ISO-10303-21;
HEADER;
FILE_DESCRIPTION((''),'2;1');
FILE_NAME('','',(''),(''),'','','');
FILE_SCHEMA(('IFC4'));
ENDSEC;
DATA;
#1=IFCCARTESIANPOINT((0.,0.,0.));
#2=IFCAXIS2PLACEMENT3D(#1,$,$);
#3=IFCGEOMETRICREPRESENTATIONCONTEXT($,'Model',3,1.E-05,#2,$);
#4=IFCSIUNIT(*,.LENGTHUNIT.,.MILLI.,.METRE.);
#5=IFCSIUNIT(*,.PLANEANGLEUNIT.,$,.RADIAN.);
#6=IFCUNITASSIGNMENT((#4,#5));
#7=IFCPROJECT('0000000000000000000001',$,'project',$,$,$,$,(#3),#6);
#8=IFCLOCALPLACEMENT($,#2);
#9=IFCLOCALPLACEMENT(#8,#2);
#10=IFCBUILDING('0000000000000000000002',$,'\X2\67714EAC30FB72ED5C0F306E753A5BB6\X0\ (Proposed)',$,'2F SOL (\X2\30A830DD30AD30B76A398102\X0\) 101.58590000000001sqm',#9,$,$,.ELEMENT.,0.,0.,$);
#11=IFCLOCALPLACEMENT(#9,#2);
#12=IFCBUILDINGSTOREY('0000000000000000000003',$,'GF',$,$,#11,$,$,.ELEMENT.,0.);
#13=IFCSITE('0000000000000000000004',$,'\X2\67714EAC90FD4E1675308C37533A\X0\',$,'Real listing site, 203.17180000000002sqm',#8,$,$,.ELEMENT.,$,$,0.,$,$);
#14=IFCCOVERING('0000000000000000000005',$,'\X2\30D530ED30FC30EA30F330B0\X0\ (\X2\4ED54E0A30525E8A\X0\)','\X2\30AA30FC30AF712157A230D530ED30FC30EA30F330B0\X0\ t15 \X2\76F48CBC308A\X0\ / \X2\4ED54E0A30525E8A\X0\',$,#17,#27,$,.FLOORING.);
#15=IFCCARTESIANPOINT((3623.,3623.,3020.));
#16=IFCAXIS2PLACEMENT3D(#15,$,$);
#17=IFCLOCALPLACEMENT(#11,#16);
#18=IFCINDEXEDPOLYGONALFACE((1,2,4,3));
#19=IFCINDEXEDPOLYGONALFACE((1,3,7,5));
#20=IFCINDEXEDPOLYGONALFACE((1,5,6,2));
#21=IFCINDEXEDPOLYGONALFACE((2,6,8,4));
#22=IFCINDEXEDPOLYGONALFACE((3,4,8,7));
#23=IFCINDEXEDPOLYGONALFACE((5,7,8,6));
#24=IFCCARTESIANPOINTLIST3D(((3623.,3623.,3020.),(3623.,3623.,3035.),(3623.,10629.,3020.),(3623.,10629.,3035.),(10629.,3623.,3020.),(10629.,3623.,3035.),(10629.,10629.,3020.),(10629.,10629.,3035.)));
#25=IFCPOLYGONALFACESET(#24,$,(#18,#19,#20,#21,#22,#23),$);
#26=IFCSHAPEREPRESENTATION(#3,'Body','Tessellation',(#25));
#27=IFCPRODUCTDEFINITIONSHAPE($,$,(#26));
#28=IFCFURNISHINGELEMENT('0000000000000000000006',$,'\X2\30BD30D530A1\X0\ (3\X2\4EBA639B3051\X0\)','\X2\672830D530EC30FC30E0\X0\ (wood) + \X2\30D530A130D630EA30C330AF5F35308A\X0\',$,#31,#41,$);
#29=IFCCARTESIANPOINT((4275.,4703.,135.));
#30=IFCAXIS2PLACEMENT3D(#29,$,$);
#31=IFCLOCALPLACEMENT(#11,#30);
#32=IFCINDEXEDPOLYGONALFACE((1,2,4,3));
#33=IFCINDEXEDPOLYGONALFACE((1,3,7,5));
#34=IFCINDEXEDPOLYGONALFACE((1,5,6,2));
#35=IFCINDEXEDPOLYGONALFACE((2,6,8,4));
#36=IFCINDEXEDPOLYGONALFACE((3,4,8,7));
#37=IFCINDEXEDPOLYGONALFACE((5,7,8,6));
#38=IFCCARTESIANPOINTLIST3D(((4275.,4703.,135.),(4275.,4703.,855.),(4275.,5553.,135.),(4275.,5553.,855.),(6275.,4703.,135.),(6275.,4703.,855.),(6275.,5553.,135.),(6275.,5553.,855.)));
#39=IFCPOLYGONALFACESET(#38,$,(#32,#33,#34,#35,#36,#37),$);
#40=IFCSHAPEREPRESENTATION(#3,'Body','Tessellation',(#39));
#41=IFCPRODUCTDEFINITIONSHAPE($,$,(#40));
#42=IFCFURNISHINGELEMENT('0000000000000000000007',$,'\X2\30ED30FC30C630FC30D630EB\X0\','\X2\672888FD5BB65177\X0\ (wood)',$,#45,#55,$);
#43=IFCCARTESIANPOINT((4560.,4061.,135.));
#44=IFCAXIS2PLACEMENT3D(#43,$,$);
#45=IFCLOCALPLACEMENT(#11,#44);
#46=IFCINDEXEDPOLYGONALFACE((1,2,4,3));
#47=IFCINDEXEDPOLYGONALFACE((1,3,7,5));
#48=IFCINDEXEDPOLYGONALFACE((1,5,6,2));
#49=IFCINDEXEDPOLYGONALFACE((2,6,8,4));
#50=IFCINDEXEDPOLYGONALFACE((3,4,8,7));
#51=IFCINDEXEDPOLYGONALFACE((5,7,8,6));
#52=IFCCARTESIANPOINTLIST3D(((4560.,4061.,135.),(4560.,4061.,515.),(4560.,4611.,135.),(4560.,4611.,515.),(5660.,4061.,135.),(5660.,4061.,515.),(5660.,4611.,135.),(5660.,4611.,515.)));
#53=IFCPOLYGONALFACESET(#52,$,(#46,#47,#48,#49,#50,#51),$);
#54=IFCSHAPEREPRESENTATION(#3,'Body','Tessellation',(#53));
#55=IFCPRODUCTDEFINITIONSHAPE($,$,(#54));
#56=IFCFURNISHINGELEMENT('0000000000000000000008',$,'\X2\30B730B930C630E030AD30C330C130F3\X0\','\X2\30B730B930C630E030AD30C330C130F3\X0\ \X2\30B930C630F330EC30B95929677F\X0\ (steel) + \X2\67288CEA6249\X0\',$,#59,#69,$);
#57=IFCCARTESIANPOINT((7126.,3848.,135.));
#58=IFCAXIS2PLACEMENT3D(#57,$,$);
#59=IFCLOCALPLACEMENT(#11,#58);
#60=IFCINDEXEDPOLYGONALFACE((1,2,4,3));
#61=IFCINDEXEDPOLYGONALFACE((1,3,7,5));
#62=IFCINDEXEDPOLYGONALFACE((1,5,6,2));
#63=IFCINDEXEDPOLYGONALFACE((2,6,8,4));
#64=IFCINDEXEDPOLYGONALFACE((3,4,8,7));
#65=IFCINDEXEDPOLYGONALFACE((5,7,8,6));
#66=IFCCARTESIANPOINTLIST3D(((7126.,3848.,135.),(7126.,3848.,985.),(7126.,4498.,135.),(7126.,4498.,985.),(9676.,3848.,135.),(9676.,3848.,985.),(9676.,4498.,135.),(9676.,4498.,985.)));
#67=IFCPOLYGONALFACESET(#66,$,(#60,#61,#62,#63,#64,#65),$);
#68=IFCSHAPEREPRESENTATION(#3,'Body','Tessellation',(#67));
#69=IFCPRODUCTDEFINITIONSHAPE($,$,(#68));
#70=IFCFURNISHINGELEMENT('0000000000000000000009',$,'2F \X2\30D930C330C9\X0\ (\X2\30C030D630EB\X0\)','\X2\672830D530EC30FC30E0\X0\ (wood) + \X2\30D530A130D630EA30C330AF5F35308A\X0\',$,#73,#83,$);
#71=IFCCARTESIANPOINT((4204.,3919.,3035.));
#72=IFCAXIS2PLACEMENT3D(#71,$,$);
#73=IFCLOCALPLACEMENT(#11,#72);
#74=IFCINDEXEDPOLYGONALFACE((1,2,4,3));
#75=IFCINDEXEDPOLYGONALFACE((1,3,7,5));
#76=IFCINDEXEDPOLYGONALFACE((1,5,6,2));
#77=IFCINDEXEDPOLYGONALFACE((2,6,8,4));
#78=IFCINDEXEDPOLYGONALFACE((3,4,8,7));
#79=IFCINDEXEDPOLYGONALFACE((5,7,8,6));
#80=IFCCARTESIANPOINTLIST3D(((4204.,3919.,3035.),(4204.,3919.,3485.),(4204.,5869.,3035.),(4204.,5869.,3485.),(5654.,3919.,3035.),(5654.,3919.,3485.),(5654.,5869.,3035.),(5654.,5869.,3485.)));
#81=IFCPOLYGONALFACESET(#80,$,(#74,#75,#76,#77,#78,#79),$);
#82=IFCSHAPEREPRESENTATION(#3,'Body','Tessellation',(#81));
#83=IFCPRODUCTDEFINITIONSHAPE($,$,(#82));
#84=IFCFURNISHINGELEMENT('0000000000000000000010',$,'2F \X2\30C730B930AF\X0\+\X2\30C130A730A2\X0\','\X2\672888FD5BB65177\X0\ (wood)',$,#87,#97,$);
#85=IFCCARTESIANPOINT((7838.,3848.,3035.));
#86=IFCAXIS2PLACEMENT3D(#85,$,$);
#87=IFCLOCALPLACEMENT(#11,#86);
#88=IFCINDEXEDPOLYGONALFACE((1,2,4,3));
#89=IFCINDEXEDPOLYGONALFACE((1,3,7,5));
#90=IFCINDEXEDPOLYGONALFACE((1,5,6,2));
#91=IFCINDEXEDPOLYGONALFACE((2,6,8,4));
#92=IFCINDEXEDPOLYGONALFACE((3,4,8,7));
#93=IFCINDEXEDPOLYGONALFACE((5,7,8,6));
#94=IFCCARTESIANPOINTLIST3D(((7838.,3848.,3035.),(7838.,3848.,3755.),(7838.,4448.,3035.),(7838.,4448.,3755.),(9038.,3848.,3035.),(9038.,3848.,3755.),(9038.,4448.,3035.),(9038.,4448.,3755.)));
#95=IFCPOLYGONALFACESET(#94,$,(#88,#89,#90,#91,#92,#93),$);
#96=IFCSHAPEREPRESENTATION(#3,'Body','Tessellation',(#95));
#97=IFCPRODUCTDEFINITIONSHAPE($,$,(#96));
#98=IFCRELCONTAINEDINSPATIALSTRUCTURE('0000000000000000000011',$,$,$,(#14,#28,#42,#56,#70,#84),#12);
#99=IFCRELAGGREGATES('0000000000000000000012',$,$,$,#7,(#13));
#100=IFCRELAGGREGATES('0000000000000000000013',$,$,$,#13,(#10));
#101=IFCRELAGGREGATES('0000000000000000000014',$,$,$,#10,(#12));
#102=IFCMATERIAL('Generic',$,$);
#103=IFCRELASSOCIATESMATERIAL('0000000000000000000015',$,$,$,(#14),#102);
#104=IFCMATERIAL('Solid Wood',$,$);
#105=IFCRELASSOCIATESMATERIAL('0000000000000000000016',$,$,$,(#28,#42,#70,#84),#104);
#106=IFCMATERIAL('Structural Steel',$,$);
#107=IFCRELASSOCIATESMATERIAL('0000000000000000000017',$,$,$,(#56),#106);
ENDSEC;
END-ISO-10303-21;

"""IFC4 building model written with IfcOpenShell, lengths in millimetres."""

from ifc_helpers import new_model, si_unit, frame, frame_2d, origin, place, context, project, spatial, rectangle, extrude, material, element, save


model = new_model("IFC4")

# Units and contexts
model_context = context("Model", 3, precision=1e-05, world=origin())
ifc_project = project(units=[si_unit("LENGTHUNIT", "METRE", prefix="MILLI"), si_unit("PLANEANGLEUNIT", "RADIAN")], contexts=[model_context])

# Site, building, storey
site_placement = place(None, origin())
site = spatial("IfcSite", under=ifc_project, at=site_placement, Name="東京都世田谷区", ObjectType="Real listing site, 203.17180000000002sqm", CompositionType="ELEMENT", RefElevation=0.0)
building_placement = place(site_placement, origin())
building = spatial("IfcBuilding", under=site, at=building_placement, Name="東京・狭小の町家 (Proposed)", ObjectType="2F SOL (エポキシ樹脂) 101.58590000000001sqm", CompositionType="ELEMENT", ElevationOfRefHeight=0.0, ElevationOfTerrain=0.0)
storey_placement = place(building_placement, origin())
storey = spatial("IfcBuildingStorey", under=building, at=storey_placement, Name="GF", CompositionType="ELEMENT", Elevation=0.0)

# Shared definitions
ifc_material_1 = material(Name="Solid Wood")

# Shared definitions
ifc_material_2 = material(Name="Structural Steel")

# Covering
ifc_material_3 = material(Name="Generic")
covering_1_placement = place(storey_placement, frame((3623.0, 3623.0, 3020.0)))
element("IfcCovering", 1, at=covering_1_placement, inside=storey, material=ifc_material_3, Name="フローリング (仕上げ床)", Description="オーク無垢フローリング t15 直貼り / 仕上げ床", PredefinedType="FLOORING", context=model_context, shape_type="SweptSolid", body=[
    extrude(rectangle(XDim=7006.0, YDim=7006.0, at=frame_2d((3503.0, 3503.0))), frame((3623.0, 3623.0, 3020.0)), (0.0, 0.0, 1.0), 15.0),
])

# Furnishing elements
furnishing_1_placement = place(storey_placement, frame((4275.0, 4703.0, 135.0)))
element("IfcFurnishingElement", 2, at=furnishing_1_placement, inside=storey, material=ifc_material_1, Name="ソファ (3人掛け)", Description="木フレーム (wood) + ファブリック張り", context=model_context, shape_type="SweptSolid", body=[
    extrude(rectangle(XDim=2000.0, YDim=850.0, at=frame_2d((1000.0, 425.0))), frame((4275.0, 4703.0, 135.0)), (0.0, 0.0, 1.0), 720.0),
])
furnishing_2_placement = place(storey_placement, frame((4560.0, 4061.0, 135.0)))
element("IfcFurnishingElement", 3, at=furnishing_2_placement, inside=storey, material=ifc_material_1, Name="ローテーブル", Description="木製家具 (wood)", context=model_context, shape_type="SweptSolid", body=[
    extrude(rectangle(XDim=1100.0, YDim=550.0, at=frame_2d((550.0, 275.0))), frame((4560.0, 4061.0, 135.0)), (0.0, 0.0, 1.0), 380.0),
])
furnishing_3_placement = place(storey_placement, frame((7126.0, 3848.0, 135.0)))
element("IfcFurnishingElement", 4, at=furnishing_3_placement, inside=storey, material=ifc_material_2, Name="システムキッチン", Description="システムキッチン ステンレス天板 (steel) + 木質扉", context=model_context, shape_type="SweptSolid", body=[
    extrude(rectangle(XDim=2550.0, YDim=650.0, at=frame_2d((1275.0, 325.0))), frame((7126.0, 3848.0, 135.0)), (0.0, 0.0, 1.0), 850.0),
])
furnishing_4_placement = place(storey_placement, frame((4204.0, 3919.0, 3035.0)))
element("IfcFurnishingElement", 5, at=furnishing_4_placement, inside=storey, material=ifc_material_1, Name="2F ベッド (ダブル)", Description="木フレーム (wood) + ファブリック張り", context=model_context, shape_type="SweptSolid", body=[
    extrude(rectangle(XDim=1450.0, YDim=1950.0, at=frame_2d((725.0, 975.0))), frame((4204.0, 3919.0, 3035.0)), (0.0, 0.0, 1.0), 450.0),
])
furnishing_5_placement = place(storey_placement, frame((7838.0, 3848.0, 3035.0)))
element("IfcFurnishingElement", 6, at=furnishing_5_placement, inside=storey, material=ifc_material_1, Name="2F デスク+チェア", Description="木製家具 (wood)", context=model_context, shape_type="SweptSolid", body=[
    extrude(rectangle(XDim=1200.0, YDim=600.0, at=frame_2d((600.0, 300.0))), frame((7838.0, 3848.0, 3035.0)), (0.0, 0.0, 1.0), 720.0),
])

save(model, "model.ifc")
